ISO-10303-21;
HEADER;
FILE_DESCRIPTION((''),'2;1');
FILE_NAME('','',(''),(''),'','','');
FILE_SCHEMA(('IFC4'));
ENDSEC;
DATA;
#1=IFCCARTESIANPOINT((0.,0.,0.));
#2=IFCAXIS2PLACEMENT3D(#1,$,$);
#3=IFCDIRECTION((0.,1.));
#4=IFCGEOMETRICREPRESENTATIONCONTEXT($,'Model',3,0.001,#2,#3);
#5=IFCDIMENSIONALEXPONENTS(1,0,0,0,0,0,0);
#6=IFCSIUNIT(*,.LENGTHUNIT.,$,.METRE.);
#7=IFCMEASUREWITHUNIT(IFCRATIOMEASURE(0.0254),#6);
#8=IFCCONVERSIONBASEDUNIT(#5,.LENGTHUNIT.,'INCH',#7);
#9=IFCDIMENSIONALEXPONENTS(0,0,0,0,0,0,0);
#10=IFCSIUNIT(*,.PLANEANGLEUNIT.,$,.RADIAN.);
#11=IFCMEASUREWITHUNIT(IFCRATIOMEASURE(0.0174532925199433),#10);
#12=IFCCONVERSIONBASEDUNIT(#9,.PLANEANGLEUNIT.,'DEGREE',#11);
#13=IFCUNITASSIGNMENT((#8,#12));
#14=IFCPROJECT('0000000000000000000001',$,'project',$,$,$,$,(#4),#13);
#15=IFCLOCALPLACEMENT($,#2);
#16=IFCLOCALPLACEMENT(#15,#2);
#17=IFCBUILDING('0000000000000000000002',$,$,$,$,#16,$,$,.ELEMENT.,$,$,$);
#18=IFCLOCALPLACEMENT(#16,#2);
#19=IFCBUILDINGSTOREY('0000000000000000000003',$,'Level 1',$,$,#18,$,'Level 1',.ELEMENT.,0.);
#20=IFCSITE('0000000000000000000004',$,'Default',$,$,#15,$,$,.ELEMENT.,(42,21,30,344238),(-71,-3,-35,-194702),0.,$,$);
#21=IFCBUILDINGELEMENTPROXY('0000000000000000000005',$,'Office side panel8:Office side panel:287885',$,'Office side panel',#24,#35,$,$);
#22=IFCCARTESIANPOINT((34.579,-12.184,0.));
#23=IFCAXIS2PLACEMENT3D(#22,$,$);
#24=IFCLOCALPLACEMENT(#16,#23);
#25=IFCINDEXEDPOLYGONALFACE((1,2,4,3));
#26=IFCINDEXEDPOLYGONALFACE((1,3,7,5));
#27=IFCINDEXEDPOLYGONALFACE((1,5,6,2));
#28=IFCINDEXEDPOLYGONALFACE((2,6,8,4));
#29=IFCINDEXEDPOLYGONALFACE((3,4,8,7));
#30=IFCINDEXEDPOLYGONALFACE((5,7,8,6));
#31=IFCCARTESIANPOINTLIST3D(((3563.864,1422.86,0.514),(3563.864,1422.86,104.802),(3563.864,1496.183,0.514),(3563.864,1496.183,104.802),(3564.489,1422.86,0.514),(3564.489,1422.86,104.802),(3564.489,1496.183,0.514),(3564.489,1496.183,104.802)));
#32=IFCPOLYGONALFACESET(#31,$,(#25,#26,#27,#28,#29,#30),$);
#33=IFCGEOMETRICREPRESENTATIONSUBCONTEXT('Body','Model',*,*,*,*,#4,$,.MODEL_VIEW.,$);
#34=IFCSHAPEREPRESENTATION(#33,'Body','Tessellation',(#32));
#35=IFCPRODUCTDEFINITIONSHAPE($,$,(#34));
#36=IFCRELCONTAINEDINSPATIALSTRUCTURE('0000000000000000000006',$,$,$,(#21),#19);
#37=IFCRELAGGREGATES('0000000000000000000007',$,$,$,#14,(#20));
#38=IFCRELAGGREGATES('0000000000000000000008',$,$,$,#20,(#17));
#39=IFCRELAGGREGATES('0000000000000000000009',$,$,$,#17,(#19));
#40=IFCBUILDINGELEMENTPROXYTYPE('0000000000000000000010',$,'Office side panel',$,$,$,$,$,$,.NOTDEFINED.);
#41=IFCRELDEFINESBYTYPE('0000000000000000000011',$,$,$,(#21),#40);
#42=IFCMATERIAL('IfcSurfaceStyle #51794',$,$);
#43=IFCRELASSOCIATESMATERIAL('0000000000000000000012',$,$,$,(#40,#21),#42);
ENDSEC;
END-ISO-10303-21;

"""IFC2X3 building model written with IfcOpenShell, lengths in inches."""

from ifc_helpers import new_model, entity, si_unit, converted_unit, direction, frame, origin, origin_2d_with_axis, place, context, subcontext, project, spatial, rectangle, extrude, source, transform, mapped, material, type_object, type_shapes, element, save


model = new_model("IFC2X3")

# Units and contexts
model_context = context("Model", 3, precision=0.001, world=origin(), true_north=direction((0.0, 1.0)))
body_context = subcontext(model_context, "Body", "Model", "MODEL_VIEW")
ifc_project = project(units=[converted_unit("LENGTHUNIT", "INCH", entity("IfcRatioMeasure", 0.0254), si_unit("LENGTHUNIT", "METRE"), dimensions=[1, 0, 0, 0, 0, 0, 0]), converted_unit("PLANEANGLEUNIT", "DEGREE", entity("IfcRatioMeasure", 0.0174532925199433), si_unit("PLANEANGLEUNIT", "RADIAN"), dimensions=[0, 0, 0, 0, 0, 0, 0])], contexts=[model_context])

# Site, building, storey
site_placement = place(None, origin())
site = spatial("IfcSite", under=ifc_project, at=site_placement, Name="Default", CompositionType="ELEMENT", RefLatitude=(42, 21, 30, 344238), RefLongitude=(-71, -3, -35, -194702), RefElevation=0.0)
building_placement = place(site_placement, origin())
building = spatial("IfcBuilding", under=site, at=building_placement, CompositionType="ELEMENT")
storey_placement = place(building_placement, origin())
storey = spatial("IfcBuildingStorey", under=building, at=storey_placement, Name="Level 1", LongName="Level 1", CompositionType="ELEMENT", Elevation=0.0)

# Building element proxy
ifc_material_1 = material(Name="IfcSurfaceStyle #51794")
building_element_proxy_type = type_object("IfcBuildingElementProxyType", Name="Office side panel", PredefinedType="NOTDEFINED", material=ifc_material_1)
shared_shape = source(origin(), body_context, "Body", "SweptSolid", [
    extrude(rectangle(XDim=0.625, YDim=73.323, at=origin_2d_with_axis()), frame((3564.177, 1459.522, 0.514)), (0.0, 0.0, 1.0), 104.288),
])
type_shapes(building_element_proxy_type, [shared_shape])
proxy_placement = place(building_placement, frame((34.579, -12.184, 0.0)))
element("IfcBuildingElementProxy", 1, at=proxy_placement, inside=storey, type_object=building_element_proxy_type, material=ifc_material_1, Name="Office side panel8:Office side panel:287885", ObjectType="Office side panel", context=body_context, shape_type="MappedRepresentation", body=[
    mapped(shared_shape, transform((0.0, 0.0, 0.0), scale=1.0)),
])

save(model, "model.ifc")
